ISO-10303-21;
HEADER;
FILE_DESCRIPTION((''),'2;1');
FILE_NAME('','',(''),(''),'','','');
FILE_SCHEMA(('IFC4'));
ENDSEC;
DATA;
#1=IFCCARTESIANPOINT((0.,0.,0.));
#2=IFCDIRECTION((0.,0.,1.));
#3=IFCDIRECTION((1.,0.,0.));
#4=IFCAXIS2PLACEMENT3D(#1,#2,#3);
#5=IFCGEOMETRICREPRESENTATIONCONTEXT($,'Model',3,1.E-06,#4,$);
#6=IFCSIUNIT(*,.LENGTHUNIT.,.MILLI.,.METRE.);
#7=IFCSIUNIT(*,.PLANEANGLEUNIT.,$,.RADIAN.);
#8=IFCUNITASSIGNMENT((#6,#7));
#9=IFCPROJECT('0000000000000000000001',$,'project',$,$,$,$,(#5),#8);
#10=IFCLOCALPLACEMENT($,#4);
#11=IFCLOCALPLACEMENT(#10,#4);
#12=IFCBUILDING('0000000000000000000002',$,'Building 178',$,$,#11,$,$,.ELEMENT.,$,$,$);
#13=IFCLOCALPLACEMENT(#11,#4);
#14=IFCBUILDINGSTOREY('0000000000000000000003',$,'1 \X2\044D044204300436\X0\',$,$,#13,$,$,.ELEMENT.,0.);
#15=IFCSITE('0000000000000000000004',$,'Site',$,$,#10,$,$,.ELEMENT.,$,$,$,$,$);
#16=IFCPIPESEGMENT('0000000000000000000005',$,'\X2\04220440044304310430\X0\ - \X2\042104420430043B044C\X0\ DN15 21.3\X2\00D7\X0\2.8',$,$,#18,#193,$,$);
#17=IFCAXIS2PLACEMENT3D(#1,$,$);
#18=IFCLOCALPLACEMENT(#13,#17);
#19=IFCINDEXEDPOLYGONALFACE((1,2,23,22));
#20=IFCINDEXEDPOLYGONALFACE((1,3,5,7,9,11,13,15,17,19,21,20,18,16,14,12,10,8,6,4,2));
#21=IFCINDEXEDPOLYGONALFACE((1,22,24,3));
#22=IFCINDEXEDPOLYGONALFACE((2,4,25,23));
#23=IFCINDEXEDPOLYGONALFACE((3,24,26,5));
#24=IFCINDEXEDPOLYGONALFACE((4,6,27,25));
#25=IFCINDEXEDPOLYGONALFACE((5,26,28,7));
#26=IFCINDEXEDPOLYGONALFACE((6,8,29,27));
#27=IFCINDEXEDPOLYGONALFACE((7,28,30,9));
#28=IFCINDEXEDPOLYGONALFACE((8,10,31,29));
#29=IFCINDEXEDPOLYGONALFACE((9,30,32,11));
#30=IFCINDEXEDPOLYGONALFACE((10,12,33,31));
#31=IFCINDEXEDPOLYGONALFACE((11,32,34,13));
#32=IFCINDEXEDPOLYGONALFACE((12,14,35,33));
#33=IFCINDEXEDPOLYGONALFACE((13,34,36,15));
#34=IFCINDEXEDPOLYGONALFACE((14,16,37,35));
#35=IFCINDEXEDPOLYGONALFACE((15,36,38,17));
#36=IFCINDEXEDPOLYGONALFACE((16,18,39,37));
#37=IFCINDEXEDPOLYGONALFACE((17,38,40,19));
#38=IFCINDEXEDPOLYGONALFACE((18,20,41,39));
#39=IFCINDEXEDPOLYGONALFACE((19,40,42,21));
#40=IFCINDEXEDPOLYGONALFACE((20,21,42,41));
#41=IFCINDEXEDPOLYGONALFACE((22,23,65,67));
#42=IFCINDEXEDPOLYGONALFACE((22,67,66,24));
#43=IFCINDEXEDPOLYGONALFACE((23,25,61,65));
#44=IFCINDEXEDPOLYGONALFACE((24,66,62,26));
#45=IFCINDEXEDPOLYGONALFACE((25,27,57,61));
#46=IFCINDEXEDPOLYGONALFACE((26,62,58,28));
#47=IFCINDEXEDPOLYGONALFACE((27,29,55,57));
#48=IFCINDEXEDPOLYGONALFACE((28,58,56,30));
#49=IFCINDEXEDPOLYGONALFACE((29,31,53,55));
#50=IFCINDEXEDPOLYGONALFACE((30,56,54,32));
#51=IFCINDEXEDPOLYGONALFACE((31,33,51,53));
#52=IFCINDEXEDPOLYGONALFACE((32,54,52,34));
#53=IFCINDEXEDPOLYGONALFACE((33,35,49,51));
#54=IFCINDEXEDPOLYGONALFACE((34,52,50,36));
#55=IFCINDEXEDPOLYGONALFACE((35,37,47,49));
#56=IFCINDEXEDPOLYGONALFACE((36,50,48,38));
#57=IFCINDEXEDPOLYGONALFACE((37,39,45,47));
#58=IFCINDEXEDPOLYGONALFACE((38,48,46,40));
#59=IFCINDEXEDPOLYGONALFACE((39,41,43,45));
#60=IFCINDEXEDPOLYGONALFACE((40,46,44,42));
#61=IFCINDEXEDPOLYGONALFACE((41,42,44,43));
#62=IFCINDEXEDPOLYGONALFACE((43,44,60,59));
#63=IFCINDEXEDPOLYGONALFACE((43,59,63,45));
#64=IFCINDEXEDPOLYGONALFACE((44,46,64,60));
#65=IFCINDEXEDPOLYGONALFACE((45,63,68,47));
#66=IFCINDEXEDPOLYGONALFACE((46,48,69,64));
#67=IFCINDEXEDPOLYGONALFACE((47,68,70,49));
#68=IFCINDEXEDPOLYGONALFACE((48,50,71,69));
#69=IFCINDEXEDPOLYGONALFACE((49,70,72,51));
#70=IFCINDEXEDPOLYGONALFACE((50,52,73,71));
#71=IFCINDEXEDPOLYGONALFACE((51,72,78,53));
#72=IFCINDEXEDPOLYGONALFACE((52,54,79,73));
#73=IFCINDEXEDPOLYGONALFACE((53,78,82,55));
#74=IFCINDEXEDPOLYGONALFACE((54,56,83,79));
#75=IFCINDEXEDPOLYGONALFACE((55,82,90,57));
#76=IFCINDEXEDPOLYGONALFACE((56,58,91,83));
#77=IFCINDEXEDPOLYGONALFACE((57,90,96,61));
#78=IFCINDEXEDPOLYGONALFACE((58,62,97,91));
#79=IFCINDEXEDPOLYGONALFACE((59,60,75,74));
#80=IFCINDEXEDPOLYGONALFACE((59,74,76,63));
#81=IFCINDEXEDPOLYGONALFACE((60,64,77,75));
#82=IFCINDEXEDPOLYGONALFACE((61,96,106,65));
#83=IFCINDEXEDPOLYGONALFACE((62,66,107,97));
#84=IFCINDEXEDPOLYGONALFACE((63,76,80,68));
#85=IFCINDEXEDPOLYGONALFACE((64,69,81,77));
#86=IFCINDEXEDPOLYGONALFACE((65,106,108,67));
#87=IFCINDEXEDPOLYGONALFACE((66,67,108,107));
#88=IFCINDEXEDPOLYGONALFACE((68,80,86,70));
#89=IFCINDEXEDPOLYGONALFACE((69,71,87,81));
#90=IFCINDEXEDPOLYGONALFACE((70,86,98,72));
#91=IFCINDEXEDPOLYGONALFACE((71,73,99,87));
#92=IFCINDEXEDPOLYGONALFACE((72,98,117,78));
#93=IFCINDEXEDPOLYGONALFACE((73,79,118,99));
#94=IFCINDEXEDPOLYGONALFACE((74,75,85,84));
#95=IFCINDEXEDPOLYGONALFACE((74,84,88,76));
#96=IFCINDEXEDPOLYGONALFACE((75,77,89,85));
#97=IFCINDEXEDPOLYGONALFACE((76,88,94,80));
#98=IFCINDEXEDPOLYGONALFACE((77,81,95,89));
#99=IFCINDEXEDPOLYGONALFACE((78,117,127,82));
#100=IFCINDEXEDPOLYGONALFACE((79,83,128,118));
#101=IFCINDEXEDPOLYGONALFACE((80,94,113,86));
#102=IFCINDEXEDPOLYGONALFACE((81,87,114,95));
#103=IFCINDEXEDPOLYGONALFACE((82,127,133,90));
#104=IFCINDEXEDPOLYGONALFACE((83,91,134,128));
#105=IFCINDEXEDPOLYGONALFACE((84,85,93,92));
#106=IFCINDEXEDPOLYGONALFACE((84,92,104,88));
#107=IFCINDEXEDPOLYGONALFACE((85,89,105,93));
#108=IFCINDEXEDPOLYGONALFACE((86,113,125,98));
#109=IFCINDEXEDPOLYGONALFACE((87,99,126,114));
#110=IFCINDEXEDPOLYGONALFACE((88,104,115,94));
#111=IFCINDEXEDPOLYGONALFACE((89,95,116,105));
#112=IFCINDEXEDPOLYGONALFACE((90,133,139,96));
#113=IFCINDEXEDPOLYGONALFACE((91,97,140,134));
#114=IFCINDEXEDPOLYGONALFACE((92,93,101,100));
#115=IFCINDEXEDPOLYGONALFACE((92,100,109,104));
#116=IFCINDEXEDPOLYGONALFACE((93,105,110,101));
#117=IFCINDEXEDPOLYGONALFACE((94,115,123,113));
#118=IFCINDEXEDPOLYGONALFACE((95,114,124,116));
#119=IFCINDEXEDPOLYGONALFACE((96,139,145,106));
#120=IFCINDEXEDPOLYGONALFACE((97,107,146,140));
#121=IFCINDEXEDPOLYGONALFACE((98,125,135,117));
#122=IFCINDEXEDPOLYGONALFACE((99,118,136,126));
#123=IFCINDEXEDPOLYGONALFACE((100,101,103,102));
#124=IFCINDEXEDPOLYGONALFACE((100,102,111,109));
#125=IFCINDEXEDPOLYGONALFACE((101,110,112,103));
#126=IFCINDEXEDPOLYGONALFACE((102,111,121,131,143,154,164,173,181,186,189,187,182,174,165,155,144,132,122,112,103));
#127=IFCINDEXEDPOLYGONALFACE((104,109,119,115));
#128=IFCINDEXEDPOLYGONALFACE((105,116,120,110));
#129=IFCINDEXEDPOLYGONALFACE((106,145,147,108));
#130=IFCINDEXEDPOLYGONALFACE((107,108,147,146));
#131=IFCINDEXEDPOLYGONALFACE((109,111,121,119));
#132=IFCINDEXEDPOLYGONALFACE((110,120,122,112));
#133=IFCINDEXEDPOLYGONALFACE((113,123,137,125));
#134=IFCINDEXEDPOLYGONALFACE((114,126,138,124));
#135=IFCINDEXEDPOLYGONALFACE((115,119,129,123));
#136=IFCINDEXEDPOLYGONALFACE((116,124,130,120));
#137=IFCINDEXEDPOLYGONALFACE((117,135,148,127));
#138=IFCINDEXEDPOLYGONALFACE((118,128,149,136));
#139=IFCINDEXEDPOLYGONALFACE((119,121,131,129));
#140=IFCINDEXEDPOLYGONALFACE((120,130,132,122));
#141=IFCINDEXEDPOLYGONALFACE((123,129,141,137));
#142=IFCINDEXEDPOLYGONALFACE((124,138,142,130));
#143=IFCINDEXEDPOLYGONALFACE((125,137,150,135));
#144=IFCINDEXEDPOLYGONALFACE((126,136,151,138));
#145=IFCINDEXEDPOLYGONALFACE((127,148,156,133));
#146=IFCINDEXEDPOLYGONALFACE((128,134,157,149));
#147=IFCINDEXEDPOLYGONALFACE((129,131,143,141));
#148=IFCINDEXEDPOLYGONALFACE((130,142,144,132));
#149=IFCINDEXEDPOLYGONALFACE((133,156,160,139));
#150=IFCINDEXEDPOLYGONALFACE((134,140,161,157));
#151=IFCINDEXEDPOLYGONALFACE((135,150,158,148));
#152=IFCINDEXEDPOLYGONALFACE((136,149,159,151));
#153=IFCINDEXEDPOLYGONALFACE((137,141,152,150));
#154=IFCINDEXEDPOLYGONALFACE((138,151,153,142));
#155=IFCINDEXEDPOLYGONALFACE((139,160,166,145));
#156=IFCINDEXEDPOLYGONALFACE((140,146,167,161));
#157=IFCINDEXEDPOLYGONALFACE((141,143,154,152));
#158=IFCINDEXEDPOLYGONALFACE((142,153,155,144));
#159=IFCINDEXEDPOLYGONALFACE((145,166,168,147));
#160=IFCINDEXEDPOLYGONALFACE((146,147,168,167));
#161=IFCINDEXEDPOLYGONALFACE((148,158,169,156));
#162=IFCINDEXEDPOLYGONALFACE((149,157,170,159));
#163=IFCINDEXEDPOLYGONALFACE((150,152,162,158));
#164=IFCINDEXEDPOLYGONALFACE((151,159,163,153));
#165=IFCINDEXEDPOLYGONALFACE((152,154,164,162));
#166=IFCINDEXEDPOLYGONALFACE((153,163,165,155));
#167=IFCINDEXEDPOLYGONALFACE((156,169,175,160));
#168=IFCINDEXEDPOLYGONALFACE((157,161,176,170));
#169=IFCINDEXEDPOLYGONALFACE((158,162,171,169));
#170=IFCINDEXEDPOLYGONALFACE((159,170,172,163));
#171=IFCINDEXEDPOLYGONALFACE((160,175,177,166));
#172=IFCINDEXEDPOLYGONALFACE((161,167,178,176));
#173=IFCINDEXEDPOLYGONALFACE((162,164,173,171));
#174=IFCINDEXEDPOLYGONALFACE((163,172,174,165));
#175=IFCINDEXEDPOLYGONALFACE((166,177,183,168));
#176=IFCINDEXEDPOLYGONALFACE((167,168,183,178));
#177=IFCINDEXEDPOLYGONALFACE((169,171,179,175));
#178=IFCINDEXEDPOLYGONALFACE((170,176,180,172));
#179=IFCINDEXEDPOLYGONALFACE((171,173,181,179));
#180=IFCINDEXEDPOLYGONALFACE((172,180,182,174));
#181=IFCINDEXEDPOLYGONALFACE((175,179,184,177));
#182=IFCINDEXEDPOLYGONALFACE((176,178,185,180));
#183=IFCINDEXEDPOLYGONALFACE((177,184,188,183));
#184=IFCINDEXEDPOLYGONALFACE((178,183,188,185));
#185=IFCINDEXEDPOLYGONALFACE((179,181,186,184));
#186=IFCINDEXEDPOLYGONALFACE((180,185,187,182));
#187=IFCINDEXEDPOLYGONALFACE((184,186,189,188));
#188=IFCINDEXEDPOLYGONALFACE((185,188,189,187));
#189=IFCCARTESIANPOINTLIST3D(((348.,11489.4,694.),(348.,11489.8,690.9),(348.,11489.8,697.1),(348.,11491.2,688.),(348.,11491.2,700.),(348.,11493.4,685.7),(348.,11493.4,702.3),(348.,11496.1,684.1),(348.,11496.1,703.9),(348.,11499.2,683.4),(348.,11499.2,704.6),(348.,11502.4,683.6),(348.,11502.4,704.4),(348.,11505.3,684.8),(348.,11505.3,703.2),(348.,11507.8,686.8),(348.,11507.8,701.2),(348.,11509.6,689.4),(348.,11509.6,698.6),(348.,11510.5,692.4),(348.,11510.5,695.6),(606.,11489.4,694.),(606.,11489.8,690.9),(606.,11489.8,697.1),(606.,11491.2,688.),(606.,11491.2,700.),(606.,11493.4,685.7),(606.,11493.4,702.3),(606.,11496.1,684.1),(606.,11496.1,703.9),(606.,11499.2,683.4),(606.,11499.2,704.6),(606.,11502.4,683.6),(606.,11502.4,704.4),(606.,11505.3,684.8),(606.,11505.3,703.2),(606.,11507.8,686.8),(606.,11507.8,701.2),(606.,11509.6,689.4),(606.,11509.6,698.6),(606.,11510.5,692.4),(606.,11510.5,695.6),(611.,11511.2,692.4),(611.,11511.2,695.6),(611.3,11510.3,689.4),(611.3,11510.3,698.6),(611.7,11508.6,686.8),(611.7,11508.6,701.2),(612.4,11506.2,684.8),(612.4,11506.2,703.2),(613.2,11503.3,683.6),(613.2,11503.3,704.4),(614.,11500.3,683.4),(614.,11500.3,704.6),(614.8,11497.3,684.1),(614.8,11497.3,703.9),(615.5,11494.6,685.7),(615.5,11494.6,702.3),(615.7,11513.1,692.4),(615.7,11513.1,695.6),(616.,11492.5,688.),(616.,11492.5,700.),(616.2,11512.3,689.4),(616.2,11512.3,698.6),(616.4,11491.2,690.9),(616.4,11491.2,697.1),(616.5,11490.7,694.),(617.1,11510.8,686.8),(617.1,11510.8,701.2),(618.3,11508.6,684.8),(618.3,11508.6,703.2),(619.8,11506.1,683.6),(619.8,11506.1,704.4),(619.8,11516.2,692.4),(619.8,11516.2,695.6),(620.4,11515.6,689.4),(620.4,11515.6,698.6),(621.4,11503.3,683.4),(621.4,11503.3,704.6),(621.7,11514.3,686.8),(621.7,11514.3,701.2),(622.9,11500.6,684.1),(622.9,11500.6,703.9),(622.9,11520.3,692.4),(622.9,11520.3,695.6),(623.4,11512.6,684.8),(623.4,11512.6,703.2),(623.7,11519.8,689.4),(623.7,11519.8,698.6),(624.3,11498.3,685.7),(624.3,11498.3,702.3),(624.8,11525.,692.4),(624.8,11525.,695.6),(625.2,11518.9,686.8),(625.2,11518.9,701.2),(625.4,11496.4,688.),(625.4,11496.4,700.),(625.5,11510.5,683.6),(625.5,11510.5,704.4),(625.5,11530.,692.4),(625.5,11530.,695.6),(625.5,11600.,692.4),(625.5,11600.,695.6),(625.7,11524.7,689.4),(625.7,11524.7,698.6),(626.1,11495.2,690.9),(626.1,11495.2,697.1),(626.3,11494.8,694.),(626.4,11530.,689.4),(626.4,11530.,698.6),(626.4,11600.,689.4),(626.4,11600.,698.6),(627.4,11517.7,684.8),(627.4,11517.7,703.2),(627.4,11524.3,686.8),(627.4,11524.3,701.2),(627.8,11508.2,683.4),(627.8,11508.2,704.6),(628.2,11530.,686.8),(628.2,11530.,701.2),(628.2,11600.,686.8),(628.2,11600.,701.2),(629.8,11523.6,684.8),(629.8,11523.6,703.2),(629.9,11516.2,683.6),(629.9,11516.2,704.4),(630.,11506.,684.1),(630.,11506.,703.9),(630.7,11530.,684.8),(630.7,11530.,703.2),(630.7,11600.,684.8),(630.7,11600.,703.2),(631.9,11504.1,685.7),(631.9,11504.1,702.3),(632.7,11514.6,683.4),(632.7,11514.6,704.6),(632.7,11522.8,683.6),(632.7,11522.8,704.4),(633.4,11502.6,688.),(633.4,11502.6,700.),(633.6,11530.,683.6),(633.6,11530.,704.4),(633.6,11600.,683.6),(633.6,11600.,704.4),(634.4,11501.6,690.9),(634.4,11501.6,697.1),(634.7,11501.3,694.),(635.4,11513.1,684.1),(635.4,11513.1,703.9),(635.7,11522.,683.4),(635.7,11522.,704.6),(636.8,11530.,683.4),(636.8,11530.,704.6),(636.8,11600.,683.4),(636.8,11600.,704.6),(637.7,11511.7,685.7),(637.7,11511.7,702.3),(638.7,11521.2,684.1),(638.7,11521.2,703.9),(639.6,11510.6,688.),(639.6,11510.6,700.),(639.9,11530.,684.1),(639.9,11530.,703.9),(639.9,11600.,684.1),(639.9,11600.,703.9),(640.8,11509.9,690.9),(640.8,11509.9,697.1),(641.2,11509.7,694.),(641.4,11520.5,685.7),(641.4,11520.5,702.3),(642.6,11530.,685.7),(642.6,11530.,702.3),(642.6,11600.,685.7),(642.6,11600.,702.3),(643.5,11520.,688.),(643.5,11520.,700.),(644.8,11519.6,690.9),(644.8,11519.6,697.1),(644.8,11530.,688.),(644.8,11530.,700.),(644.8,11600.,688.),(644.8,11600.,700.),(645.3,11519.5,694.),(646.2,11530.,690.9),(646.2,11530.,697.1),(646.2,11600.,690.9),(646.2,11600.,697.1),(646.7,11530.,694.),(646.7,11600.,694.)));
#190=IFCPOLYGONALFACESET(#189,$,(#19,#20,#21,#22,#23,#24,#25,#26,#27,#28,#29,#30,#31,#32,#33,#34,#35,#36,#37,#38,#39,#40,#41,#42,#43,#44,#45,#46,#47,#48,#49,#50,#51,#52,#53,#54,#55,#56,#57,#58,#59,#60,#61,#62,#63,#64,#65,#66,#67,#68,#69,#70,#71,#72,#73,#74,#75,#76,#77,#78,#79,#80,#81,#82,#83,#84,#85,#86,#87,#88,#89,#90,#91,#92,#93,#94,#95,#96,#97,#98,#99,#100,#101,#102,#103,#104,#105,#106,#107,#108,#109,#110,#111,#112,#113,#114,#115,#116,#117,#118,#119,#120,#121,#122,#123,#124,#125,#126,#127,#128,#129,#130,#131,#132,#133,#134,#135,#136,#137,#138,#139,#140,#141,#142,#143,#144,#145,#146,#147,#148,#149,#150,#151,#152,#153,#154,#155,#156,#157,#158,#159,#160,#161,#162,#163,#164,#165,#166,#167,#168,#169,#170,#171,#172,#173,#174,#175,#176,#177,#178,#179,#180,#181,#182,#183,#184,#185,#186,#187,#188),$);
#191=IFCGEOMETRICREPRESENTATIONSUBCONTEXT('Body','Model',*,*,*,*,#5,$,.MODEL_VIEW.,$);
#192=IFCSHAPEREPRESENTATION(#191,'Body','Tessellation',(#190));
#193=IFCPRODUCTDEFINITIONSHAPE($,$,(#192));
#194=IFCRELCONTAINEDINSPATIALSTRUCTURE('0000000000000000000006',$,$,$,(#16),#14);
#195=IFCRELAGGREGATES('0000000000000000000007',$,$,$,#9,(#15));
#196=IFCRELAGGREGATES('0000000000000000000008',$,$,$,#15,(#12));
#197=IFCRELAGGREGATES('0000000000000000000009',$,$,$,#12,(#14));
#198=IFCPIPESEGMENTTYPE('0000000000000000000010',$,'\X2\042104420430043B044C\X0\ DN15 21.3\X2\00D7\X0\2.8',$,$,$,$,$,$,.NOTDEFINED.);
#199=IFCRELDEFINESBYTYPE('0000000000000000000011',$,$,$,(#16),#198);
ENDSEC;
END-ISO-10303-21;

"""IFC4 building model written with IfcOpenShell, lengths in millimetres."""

from ifc_helpers import new_model, entity, si_unit, frame, origin_with_axes, place, context, subcontext, project, spatial, source, transform, mapped, type_object, element, save


model = new_model("IFC4")

# Units and contexts
model_context = context("Model", 3, precision=1e-06, world=origin_with_axes())
body_context = subcontext(model_context, "Body", "Model", "MODEL_VIEW")
ifc_project = project(units=[si_unit("LENGTHUNIT", "METRE", prefix="MILLI"), si_unit("PLANEANGLEUNIT", "RADIAN")], contexts=[model_context])

# Site, building, storey
site_placement = place(None, origin_with_axes())
site = spatial("IfcSite", under=ifc_project, at=site_placement, Name="Site", CompositionType="ELEMENT")
building_placement = place(site_placement, origin_with_axes())
building = spatial("IfcBuilding", under=site, at=building_placement, Name="Building 178", CompositionType="ELEMENT")
storey_placement = place(building_placement, origin_with_axes())
storey = spatial("IfcBuildingStorey", under=building, at=storey_placement, Name="1 этаж", CompositionType="ELEMENT", Elevation=0.0)

# Pipe segment
pipe_segment_type = type_object("IfcPipeSegmentType", Name="Сталь DN15 21.3×2.8", PredefinedType="NOTDEFINED")
shared_shape_1 = source(origin_with_axes(), body_context, "Body", "AdvancedSweptSolid", [
    entity("IfcSweptDiskSolid", entity("IfcIndexedPolyCurve", entity("IfcCartesianPointList3D", [[0.0, 0.0, 0.0], [0.0, 0.0, -70.0], [8.8, 0.0, -91.2], [30.0, 0.0, -100.0], [288.0, 0.0, -100.0]]), [entity("IfcLineIndex", [1, 2]), entity("IfcArcIndex", [2, 3, 4]), entity("IfcLineIndex", [4, 5])]), 10.7),
])
for number, where, z_axis, x_axis, name in (
    (1, (636.0, 11600.0, 694.0), (0.0, 1.0, 0.0), (-1.0, 0.0, 0.0), "Труба - Сталь DN15 21.3×2.8"),
):
    element("IfcPipeSegment", number, at=place(storey_placement, frame(where, z_axis=z_axis, x_axis=x_axis)), inside=storey, type_object=pipe_segment_type, Name=name, context=body_context, shape_type="MappedRepresentation", body=[
        mapped(shared_shape_1, transform((0.0, 0.0, 0.0), x_axis=(1.0, 0.0, 0.0), y_axis=(0.0, 1.0, 0.0), z_axis=(0.0, 0.0, 1.0), scale=1.0)),
    ])

save(model, "model.ifc")
